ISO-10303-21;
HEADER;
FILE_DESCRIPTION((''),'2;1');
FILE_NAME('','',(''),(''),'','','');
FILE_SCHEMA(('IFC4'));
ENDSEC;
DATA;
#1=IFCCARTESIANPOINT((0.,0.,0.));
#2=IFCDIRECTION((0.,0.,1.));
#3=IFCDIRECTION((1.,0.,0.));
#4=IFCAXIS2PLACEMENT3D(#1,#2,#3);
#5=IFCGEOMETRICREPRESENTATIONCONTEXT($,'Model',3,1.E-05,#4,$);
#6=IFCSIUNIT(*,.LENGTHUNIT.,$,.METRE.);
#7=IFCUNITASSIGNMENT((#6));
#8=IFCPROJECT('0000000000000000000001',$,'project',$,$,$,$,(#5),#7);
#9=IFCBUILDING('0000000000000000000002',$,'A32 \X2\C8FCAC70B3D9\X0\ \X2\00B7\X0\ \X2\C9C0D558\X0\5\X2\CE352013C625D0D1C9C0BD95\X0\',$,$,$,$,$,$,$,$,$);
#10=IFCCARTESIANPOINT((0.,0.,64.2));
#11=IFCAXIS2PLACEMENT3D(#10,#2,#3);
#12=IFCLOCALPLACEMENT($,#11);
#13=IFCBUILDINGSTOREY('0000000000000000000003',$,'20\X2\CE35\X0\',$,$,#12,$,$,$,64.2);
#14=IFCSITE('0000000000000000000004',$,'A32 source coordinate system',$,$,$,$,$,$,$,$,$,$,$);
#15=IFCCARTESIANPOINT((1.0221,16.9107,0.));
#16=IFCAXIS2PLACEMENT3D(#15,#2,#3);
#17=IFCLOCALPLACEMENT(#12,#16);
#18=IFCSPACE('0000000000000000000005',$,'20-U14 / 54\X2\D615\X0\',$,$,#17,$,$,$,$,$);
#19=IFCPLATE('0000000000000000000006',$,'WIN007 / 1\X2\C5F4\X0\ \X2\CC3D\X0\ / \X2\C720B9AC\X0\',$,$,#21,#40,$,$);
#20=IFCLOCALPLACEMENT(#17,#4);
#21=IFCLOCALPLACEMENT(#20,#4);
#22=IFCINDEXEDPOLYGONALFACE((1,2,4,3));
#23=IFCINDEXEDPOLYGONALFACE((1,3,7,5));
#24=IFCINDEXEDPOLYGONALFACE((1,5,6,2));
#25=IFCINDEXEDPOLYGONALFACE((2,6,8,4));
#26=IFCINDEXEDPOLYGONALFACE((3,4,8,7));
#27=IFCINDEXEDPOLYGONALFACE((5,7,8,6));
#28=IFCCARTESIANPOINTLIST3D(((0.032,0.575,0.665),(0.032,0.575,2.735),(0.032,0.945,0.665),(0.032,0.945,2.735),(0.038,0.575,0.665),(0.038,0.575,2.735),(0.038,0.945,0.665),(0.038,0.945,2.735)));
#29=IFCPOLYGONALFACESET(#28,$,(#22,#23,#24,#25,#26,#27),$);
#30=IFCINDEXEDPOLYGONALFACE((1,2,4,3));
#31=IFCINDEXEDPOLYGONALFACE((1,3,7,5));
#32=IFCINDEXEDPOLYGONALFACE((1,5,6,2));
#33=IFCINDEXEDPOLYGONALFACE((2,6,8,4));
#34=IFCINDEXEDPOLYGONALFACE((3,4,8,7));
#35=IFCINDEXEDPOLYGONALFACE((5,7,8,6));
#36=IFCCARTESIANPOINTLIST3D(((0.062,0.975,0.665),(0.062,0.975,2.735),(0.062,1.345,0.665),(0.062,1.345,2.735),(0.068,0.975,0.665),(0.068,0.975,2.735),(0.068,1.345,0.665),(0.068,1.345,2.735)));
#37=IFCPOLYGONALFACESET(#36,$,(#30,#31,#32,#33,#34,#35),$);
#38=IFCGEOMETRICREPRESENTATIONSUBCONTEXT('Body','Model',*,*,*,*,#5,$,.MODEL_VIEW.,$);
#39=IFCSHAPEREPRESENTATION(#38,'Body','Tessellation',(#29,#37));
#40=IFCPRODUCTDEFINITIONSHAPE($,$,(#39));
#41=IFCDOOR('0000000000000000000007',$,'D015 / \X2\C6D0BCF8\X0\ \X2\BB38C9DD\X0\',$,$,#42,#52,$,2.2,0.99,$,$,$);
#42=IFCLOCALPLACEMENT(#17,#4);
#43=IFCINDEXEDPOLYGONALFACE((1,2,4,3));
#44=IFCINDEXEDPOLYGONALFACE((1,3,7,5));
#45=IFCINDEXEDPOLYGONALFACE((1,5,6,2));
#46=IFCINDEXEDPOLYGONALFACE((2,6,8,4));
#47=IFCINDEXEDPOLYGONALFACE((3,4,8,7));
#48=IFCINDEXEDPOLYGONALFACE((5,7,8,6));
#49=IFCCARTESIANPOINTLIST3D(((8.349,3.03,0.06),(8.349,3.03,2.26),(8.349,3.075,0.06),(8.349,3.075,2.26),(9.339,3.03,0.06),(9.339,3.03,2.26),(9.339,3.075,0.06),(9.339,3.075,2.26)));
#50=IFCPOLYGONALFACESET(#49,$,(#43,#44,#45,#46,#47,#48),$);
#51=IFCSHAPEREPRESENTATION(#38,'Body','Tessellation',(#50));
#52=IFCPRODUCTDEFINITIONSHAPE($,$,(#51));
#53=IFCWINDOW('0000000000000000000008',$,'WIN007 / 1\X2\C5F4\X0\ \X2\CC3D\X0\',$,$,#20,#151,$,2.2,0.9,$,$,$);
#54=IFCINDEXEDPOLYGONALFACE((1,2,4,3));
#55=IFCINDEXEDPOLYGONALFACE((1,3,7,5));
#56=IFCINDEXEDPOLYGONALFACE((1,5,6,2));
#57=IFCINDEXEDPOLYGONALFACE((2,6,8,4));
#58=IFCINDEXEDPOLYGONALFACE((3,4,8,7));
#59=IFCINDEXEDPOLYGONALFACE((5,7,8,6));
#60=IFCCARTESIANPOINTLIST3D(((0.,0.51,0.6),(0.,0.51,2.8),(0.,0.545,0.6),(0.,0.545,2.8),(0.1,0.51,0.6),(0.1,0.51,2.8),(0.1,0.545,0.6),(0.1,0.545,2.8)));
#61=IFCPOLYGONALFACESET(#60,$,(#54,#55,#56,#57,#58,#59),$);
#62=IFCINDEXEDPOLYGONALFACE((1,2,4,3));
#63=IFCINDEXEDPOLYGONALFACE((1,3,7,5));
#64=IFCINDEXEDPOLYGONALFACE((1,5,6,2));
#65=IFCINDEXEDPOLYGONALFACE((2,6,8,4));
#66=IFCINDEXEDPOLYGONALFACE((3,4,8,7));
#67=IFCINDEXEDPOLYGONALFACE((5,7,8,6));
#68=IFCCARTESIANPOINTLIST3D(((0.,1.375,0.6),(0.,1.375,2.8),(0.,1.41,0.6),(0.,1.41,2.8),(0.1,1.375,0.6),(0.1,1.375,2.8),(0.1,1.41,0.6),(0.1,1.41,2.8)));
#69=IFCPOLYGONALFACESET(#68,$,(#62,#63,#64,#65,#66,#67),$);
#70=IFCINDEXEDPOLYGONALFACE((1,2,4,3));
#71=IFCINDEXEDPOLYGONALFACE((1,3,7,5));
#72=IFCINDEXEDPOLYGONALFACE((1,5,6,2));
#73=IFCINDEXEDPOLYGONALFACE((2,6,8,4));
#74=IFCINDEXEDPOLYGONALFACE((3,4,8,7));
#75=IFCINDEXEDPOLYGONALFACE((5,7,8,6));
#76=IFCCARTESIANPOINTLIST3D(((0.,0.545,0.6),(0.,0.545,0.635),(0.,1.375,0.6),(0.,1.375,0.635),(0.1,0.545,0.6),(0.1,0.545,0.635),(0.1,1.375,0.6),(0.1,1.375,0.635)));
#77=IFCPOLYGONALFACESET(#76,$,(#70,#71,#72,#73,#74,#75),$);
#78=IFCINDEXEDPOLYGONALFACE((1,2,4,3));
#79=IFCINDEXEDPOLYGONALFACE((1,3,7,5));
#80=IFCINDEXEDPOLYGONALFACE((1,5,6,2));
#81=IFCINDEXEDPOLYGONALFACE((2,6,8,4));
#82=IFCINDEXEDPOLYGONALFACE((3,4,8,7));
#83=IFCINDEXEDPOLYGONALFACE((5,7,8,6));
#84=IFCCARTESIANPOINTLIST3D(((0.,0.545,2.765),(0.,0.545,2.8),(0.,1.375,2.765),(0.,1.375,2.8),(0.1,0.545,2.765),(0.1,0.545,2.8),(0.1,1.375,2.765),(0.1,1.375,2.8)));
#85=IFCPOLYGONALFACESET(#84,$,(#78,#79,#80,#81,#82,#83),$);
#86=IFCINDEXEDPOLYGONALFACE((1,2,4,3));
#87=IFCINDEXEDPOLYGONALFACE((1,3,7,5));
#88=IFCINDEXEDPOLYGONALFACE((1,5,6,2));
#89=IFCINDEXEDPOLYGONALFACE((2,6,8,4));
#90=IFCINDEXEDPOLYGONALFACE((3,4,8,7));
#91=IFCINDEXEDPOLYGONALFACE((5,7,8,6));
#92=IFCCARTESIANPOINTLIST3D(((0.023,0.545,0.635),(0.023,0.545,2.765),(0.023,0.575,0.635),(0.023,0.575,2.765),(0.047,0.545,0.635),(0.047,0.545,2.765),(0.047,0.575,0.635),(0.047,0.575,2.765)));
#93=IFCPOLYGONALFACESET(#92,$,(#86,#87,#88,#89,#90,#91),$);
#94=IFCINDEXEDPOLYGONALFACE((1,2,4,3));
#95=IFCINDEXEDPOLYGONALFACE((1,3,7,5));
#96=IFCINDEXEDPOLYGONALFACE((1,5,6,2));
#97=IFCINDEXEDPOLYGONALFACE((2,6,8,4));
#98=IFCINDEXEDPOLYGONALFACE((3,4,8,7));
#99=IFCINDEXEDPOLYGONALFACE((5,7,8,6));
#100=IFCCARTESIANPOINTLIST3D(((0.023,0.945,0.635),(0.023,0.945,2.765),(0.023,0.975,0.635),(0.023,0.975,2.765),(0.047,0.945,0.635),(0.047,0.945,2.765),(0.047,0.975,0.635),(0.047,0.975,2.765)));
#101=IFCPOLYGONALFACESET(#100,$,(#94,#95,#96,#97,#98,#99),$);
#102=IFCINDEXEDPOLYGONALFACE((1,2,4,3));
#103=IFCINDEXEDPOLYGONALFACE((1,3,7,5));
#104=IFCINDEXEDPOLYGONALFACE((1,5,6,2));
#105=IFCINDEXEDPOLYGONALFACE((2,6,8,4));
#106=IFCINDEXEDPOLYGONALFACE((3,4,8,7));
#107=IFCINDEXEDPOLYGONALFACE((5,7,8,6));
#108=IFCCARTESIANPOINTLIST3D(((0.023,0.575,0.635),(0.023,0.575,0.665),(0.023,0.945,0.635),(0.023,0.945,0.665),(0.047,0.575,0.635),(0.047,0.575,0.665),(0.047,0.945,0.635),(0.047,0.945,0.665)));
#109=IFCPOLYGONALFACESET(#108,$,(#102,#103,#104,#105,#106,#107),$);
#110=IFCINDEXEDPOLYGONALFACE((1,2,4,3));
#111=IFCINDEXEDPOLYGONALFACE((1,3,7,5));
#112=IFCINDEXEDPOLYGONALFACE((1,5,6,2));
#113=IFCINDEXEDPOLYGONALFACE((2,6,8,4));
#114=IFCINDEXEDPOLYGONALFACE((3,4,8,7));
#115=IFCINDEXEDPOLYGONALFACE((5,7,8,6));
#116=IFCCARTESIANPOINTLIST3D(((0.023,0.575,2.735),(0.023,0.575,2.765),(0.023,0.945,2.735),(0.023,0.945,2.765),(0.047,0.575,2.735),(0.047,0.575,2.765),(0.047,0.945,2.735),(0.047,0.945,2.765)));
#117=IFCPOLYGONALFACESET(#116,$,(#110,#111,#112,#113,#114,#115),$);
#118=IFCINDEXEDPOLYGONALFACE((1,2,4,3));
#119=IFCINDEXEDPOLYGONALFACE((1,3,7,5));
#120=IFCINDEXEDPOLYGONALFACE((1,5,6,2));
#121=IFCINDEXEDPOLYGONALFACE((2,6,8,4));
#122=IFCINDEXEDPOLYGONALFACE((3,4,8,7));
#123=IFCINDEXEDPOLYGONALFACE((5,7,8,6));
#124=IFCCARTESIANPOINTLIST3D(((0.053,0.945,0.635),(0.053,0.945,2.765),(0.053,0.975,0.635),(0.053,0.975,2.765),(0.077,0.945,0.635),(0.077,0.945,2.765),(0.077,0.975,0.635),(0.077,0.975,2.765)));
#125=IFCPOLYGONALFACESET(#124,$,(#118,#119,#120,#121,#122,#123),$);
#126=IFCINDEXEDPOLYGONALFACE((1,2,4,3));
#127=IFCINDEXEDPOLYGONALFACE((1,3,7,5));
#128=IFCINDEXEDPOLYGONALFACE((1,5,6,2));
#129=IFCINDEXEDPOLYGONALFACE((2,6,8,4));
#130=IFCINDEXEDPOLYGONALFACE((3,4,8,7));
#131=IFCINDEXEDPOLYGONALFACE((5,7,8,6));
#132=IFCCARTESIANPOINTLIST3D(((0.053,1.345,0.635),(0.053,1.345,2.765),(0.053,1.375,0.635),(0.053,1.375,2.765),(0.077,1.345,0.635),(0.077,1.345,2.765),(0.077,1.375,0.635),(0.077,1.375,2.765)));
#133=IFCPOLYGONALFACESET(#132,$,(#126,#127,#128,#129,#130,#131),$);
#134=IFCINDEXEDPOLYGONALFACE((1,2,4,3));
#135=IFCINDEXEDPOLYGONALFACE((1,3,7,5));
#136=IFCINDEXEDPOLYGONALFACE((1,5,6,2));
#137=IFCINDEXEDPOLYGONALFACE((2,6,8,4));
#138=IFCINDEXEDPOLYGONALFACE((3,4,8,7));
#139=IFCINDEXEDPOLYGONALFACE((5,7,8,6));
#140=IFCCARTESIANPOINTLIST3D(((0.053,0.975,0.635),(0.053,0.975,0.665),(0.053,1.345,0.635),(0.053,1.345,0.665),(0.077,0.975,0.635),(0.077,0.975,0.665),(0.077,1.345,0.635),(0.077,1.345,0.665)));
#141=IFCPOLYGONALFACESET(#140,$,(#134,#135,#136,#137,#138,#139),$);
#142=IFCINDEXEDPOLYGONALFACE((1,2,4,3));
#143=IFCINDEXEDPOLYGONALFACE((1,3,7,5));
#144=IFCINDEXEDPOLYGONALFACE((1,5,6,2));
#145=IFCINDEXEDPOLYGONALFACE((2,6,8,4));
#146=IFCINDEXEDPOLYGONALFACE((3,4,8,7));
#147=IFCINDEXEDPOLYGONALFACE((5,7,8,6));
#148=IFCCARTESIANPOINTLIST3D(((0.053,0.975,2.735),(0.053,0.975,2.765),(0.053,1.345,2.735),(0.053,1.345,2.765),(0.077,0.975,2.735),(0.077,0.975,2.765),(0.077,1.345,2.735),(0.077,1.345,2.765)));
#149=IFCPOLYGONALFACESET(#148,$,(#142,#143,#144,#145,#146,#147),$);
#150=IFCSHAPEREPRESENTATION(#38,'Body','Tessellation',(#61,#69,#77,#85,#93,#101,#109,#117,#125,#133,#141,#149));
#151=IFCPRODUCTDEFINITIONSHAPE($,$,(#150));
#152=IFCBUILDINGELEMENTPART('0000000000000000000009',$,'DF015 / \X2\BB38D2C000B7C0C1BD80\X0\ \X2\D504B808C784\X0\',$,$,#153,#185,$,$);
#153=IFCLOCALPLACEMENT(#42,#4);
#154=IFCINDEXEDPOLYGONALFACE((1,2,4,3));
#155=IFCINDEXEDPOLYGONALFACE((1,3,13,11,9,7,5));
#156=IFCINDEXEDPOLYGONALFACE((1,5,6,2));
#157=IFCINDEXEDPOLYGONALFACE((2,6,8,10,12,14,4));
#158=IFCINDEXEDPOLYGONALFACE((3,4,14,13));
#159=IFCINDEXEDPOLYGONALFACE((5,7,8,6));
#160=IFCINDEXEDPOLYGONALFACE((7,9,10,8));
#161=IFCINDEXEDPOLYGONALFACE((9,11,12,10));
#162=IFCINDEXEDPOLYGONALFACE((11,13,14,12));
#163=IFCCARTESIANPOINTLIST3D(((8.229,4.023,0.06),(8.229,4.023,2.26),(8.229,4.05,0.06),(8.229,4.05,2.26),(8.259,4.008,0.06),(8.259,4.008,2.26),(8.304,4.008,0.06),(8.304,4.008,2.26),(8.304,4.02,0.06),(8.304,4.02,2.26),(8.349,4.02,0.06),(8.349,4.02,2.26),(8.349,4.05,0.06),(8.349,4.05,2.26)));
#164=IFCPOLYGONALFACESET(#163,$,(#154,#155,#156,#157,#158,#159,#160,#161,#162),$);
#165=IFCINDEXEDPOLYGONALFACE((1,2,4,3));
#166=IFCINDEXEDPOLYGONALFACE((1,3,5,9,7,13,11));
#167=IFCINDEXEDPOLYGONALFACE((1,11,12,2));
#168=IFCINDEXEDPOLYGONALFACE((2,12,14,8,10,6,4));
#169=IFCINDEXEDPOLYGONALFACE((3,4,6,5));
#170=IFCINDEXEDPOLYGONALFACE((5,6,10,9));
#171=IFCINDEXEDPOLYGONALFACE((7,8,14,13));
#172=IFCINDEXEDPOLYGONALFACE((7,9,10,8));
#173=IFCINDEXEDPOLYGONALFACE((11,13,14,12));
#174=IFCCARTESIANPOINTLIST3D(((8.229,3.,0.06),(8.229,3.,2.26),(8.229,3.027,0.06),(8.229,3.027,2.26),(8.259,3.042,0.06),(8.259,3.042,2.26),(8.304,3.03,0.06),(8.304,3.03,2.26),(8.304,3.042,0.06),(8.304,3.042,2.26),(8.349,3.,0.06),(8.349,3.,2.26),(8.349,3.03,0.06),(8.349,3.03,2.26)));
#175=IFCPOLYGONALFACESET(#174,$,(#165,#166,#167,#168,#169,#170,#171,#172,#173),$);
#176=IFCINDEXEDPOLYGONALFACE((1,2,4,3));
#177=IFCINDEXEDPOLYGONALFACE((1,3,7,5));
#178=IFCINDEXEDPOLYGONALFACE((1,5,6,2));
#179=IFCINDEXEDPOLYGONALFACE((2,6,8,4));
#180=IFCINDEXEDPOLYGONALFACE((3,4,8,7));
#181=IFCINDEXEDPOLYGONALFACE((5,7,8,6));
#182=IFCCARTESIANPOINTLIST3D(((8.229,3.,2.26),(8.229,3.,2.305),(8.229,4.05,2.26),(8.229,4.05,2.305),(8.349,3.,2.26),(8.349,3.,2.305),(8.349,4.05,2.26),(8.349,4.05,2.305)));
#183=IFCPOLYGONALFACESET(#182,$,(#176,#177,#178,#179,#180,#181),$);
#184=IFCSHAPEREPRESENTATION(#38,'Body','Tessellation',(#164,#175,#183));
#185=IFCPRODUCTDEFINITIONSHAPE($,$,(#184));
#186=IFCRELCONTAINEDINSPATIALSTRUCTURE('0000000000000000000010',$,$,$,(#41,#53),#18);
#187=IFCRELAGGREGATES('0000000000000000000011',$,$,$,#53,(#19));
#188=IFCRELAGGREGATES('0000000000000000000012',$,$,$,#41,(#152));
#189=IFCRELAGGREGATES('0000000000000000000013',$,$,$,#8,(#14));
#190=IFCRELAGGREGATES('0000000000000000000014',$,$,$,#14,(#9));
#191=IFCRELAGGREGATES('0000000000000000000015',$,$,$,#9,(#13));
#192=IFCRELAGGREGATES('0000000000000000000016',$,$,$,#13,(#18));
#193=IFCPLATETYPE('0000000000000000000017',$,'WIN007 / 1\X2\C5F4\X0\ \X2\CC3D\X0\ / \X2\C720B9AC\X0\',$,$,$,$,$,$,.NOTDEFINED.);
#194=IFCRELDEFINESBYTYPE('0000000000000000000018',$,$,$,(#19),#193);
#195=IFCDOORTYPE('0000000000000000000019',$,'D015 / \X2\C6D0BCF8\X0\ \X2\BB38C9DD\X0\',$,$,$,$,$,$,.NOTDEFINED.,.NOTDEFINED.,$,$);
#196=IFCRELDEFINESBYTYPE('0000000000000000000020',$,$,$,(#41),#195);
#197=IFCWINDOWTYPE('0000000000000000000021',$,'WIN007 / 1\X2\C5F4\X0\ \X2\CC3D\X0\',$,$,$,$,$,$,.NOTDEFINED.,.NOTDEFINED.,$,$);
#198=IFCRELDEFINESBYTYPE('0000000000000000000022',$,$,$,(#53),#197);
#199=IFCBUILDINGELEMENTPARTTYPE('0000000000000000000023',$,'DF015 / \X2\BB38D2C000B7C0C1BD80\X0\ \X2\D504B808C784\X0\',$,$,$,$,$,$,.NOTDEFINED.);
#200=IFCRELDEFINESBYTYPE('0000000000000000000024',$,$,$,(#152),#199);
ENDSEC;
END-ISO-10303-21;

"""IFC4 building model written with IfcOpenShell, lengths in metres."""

from ifc_helpers import new_model, si_unit, frame, origin, origin_with_axes, place, context, subcontext, project, spatial, polyline, outline, extrude, source, transform, mapped, type_object, type_shapes, element, aggregate, save


model = new_model("IFC4")

# Units and contexts
model_context = context("Model", 3, precision=1e-05, world=origin_with_axes())
body_context = subcontext(model_context, "Body", "Model", "MODEL_VIEW")
ifc_project = project(units=[si_unit("LENGTHUNIT", "METRE")], contexts=[model_context])

# Plate
plate_type_1 = type_object("IfcPlateType", Name="WIN007 / 1열 창 / 유리", PredefinedType="NOTDEFINED")
shared_shape_1 = source(origin(), body_context, "Body", "SweptSolid", [
    extrude(outline(polyline([(0.032, 0.575), (0.032, 0.945), (0.038, 0.945), (0.038, 0.575), (0.032, 0.575)])), frame((0.0, 0.0, 0.665)), (0.0, 0.0, 1.0), 2.07),
    extrude(outline(polyline([(0.062, 0.975), (0.062, 1.345), (0.068, 1.345), (0.068, 0.975), (0.062, 0.975)])), frame((0.0, 0.0, 0.665)), (0.0, 0.0, 1.0), 2.07),
])
type_shapes(plate_type_1, [shared_shape_1])
storey_placement = place(None, frame((0.0, 0.0, 64.2), z_axis=(0.0, 0.0, 1.0), x_axis=(1.0, 0.0, 0.0)))
space_1_placement = place(storey_placement, frame((1.0221, 16.9107, 0.0), z_axis=(0.0, 0.0, 1.0), x_axis=(1.0, 0.0, 0.0)))
window_1_placement = place(space_1_placement, origin_with_axes())
plate_1_placement = place(window_1_placement, origin_with_axes())
plate_1 = element("IfcPlate", 1, at=plate_1_placement, type_object=plate_type_1, Name="WIN007 / 1열 창 / 유리", context=body_context, shape_type="MappedRepresentation", body=[
    mapped(shared_shape_1, transform((0.0, 0.0, 0.0), scale=1.0)),
])

# Site, building, storey, space
site = spatial("IfcSite", under=ifc_project, Name="A32 source coordinate system")
building = spatial("IfcBuilding", under=site, Name="A32 주거동 · 지하5층–옥탑지붕")
storey = spatial("IfcBuildingStorey", under=building, at=storey_placement, Name="20층", Elevation=64.2)
space_1 = spatial("IfcSpace", under=storey, at=space_1_placement, Name="20-U14 / 54형")

# Door
door_type_1 = type_object("IfcDoorType", Name="D015 / 원본 문짝", OperationType="NOTDEFINED", PredefinedType="NOTDEFINED")
shared_shape_2 = source(origin(), body_context, "Body", "SweptSolid", [
    extrude(outline(polyline([(9.339, 3.075), (9.339, 3.03), (8.349, 3.03), (8.349, 3.075), (9.339, 3.075)])), frame((0.0, 0.0, 0.06)), (0.0, 0.0, 1.0), 2.2),
])
type_shapes(door_type_1, [shared_shape_2])
door_1_placement = place(space_1_placement, origin_with_axes())
door_1 = element("IfcDoor", 2, at=door_1_placement, inside=space_1, type_object=door_type_1, Name="D015 / 원본 문짝", OverallHeight=2.2, OverallWidth=0.99, context=body_context, shape_type="MappedRepresentation", body=[
    mapped(shared_shape_2, transform((0.0, 0.0, 0.0), scale=1.0)),
])

# Window
window_type_1 = type_object("IfcWindowType", Name="WIN007 / 1열 창", PartitioningType="NOTDEFINED", PredefinedType="NOTDEFINED")
shared_shape_3 = source(origin(), body_context, "Body", "SweptSolid", [
    extrude(outline(polyline([(0.0, 0.51), (0.0, 0.545), (0.1, 0.545), (0.1, 0.51), (0.0, 0.51)])), frame((0.0, 0.0, 0.6)), (0.0, 0.0, 1.0), 2.2),
    extrude(outline(polyline([(0.0, 1.375), (0.0, 1.41), (0.1, 1.41), (0.1, 1.375), (0.0, 1.375)])), frame((0.0, 0.0, 0.6)), (0.0, 0.0, 1.0), 2.2),
    extrude(outline(polyline([(0.0, 0.545), (0.0, 1.375), (0.1, 1.375), (0.1, 0.545), (0.0, 0.545)])), frame((0.0, 0.0, 0.6)), (0.0, 0.0, 1.0), 0.035),
    extrude(outline(polyline([(0.0, 0.545), (0.0, 1.375), (0.1, 1.375), (0.1, 0.545), (0.0, 0.545)])), frame((0.0, 0.0, 2.765)), (0.0, 0.0, 1.0), 0.035),
    extrude(outline(polyline([(0.023, 0.545), (0.023, 0.575), (0.047, 0.575), (0.047, 0.545), (0.023, 0.545)])), frame((0.0, 0.0, 0.635)), (0.0, 0.0, 1.0), 2.13),
    extrude(outline(polyline([(0.023, 0.945), (0.023, 0.975), (0.047, 0.975), (0.047, 0.945), (0.023, 0.945)])), frame((0.0, 0.0, 0.635)), (0.0, 0.0, 1.0), 2.13),
    extrude(outline(polyline([(0.023, 0.575), (0.023, 0.945), (0.047, 0.945), (0.047, 0.575), (0.023, 0.575)])), frame((0.0, 0.0, 0.635)), (0.0, 0.0, 1.0), 0.03),
    extrude(outline(polyline([(0.023, 0.575), (0.023, 0.945), (0.047, 0.945), (0.047, 0.575), (0.023, 0.575)])), frame((0.0, 0.0, 2.735)), (0.0, 0.0, 1.0), 0.03),
    extrude(outline(polyline([(0.053, 0.945), (0.053, 0.975), (0.077, 0.975), (0.077, 0.945), (0.053, 0.945)])), frame((0.0, 0.0, 0.635)), (0.0, 0.0, 1.0), 2.13),
    extrude(outline(polyline([(0.053, 1.345), (0.053, 1.375), (0.077, 1.375), (0.077, 1.345), (0.053, 1.345)])), frame((0.0, 0.0, 0.635)), (0.0, 0.0, 1.0), 2.13),
    extrude(outline(polyline([(0.053, 0.975), (0.053, 1.345), (0.077, 1.345), (0.077, 0.975), (0.053, 0.975)])), frame((0.0, 0.0, 0.635)), (0.0, 0.0, 1.0), 0.03),
    extrude(outline(polyline([(0.053, 0.975), (0.053, 1.345), (0.077, 1.345), (0.077, 0.975), (0.053, 0.975)])), frame((0.0, 0.0, 2.735)), (0.0, 0.0, 1.0), 0.03),
])
type_shapes(window_type_1, [shared_shape_3])
window_1 = element("IfcWindow", 3, at=window_1_placement, inside=space_1, type_object=window_type_1, Name="WIN007 / 1열 창", OverallHeight=2.2, OverallWidth=0.9, context=body_context, shape_type="MappedRepresentation", body=[
    mapped(shared_shape_3, transform((0.0, 0.0, 0.0), scale=1.0)),
])
aggregate(window_1, [plate_1])

# Building element part
building_element_part_type_1 = type_object("IfcBuildingElementPartType", Name="DF015 / 문틀·상부 프레임", PredefinedType="NOTDEFINED")
shared_shape_4 = source(origin(), body_context, "Body", "SweptSolid", [
    extrude(outline(polyline([(8.349, 4.02), (8.304, 4.02), (8.304, 4.008), (8.259, 4.008), (8.229, 4.023), (8.229, 4.05), (8.349, 4.05), (8.349, 4.02)])), frame((0.0, 0.0, 0.06)), (0.0, 0.0, 1.0), 2.2),
    extrude(outline(polyline([(8.229, 3.0), (8.229, 3.027), (8.259, 3.042), (8.304, 3.042), (8.304, 3.03), (8.349, 3.03), (8.349, 3.0), (8.229, 3.0)])), frame((0.0, 0.0, 0.06)), (0.0, 0.0, 1.0), 2.2),
    extrude(outline(polyline([(8.229, 3.0), (8.229, 4.05), (8.349, 4.05), (8.349, 3.0), (8.229, 3.0)])), frame((0.0, 0.0, 2.26)), (0.0, 0.0, 1.0), 0.045),
])
type_shapes(building_element_part_type_1, [shared_shape_4])
building_element_part_1_placement = place(door_1_placement, origin_with_axes())
building_element_part_1 = element("IfcBuildingElementPart", 4, at=building_element_part_1_placement, type_object=building_element_part_type_1, Name="DF015 / 문틀·상부 프레임", context=body_context, shape_type="MappedRepresentation", body=[
    mapped(shared_shape_4, transform((0.0, 0.0, 0.0), scale=1.0)),
])
aggregate(door_1, [building_element_part_1])

save(model, "model.ifc")
